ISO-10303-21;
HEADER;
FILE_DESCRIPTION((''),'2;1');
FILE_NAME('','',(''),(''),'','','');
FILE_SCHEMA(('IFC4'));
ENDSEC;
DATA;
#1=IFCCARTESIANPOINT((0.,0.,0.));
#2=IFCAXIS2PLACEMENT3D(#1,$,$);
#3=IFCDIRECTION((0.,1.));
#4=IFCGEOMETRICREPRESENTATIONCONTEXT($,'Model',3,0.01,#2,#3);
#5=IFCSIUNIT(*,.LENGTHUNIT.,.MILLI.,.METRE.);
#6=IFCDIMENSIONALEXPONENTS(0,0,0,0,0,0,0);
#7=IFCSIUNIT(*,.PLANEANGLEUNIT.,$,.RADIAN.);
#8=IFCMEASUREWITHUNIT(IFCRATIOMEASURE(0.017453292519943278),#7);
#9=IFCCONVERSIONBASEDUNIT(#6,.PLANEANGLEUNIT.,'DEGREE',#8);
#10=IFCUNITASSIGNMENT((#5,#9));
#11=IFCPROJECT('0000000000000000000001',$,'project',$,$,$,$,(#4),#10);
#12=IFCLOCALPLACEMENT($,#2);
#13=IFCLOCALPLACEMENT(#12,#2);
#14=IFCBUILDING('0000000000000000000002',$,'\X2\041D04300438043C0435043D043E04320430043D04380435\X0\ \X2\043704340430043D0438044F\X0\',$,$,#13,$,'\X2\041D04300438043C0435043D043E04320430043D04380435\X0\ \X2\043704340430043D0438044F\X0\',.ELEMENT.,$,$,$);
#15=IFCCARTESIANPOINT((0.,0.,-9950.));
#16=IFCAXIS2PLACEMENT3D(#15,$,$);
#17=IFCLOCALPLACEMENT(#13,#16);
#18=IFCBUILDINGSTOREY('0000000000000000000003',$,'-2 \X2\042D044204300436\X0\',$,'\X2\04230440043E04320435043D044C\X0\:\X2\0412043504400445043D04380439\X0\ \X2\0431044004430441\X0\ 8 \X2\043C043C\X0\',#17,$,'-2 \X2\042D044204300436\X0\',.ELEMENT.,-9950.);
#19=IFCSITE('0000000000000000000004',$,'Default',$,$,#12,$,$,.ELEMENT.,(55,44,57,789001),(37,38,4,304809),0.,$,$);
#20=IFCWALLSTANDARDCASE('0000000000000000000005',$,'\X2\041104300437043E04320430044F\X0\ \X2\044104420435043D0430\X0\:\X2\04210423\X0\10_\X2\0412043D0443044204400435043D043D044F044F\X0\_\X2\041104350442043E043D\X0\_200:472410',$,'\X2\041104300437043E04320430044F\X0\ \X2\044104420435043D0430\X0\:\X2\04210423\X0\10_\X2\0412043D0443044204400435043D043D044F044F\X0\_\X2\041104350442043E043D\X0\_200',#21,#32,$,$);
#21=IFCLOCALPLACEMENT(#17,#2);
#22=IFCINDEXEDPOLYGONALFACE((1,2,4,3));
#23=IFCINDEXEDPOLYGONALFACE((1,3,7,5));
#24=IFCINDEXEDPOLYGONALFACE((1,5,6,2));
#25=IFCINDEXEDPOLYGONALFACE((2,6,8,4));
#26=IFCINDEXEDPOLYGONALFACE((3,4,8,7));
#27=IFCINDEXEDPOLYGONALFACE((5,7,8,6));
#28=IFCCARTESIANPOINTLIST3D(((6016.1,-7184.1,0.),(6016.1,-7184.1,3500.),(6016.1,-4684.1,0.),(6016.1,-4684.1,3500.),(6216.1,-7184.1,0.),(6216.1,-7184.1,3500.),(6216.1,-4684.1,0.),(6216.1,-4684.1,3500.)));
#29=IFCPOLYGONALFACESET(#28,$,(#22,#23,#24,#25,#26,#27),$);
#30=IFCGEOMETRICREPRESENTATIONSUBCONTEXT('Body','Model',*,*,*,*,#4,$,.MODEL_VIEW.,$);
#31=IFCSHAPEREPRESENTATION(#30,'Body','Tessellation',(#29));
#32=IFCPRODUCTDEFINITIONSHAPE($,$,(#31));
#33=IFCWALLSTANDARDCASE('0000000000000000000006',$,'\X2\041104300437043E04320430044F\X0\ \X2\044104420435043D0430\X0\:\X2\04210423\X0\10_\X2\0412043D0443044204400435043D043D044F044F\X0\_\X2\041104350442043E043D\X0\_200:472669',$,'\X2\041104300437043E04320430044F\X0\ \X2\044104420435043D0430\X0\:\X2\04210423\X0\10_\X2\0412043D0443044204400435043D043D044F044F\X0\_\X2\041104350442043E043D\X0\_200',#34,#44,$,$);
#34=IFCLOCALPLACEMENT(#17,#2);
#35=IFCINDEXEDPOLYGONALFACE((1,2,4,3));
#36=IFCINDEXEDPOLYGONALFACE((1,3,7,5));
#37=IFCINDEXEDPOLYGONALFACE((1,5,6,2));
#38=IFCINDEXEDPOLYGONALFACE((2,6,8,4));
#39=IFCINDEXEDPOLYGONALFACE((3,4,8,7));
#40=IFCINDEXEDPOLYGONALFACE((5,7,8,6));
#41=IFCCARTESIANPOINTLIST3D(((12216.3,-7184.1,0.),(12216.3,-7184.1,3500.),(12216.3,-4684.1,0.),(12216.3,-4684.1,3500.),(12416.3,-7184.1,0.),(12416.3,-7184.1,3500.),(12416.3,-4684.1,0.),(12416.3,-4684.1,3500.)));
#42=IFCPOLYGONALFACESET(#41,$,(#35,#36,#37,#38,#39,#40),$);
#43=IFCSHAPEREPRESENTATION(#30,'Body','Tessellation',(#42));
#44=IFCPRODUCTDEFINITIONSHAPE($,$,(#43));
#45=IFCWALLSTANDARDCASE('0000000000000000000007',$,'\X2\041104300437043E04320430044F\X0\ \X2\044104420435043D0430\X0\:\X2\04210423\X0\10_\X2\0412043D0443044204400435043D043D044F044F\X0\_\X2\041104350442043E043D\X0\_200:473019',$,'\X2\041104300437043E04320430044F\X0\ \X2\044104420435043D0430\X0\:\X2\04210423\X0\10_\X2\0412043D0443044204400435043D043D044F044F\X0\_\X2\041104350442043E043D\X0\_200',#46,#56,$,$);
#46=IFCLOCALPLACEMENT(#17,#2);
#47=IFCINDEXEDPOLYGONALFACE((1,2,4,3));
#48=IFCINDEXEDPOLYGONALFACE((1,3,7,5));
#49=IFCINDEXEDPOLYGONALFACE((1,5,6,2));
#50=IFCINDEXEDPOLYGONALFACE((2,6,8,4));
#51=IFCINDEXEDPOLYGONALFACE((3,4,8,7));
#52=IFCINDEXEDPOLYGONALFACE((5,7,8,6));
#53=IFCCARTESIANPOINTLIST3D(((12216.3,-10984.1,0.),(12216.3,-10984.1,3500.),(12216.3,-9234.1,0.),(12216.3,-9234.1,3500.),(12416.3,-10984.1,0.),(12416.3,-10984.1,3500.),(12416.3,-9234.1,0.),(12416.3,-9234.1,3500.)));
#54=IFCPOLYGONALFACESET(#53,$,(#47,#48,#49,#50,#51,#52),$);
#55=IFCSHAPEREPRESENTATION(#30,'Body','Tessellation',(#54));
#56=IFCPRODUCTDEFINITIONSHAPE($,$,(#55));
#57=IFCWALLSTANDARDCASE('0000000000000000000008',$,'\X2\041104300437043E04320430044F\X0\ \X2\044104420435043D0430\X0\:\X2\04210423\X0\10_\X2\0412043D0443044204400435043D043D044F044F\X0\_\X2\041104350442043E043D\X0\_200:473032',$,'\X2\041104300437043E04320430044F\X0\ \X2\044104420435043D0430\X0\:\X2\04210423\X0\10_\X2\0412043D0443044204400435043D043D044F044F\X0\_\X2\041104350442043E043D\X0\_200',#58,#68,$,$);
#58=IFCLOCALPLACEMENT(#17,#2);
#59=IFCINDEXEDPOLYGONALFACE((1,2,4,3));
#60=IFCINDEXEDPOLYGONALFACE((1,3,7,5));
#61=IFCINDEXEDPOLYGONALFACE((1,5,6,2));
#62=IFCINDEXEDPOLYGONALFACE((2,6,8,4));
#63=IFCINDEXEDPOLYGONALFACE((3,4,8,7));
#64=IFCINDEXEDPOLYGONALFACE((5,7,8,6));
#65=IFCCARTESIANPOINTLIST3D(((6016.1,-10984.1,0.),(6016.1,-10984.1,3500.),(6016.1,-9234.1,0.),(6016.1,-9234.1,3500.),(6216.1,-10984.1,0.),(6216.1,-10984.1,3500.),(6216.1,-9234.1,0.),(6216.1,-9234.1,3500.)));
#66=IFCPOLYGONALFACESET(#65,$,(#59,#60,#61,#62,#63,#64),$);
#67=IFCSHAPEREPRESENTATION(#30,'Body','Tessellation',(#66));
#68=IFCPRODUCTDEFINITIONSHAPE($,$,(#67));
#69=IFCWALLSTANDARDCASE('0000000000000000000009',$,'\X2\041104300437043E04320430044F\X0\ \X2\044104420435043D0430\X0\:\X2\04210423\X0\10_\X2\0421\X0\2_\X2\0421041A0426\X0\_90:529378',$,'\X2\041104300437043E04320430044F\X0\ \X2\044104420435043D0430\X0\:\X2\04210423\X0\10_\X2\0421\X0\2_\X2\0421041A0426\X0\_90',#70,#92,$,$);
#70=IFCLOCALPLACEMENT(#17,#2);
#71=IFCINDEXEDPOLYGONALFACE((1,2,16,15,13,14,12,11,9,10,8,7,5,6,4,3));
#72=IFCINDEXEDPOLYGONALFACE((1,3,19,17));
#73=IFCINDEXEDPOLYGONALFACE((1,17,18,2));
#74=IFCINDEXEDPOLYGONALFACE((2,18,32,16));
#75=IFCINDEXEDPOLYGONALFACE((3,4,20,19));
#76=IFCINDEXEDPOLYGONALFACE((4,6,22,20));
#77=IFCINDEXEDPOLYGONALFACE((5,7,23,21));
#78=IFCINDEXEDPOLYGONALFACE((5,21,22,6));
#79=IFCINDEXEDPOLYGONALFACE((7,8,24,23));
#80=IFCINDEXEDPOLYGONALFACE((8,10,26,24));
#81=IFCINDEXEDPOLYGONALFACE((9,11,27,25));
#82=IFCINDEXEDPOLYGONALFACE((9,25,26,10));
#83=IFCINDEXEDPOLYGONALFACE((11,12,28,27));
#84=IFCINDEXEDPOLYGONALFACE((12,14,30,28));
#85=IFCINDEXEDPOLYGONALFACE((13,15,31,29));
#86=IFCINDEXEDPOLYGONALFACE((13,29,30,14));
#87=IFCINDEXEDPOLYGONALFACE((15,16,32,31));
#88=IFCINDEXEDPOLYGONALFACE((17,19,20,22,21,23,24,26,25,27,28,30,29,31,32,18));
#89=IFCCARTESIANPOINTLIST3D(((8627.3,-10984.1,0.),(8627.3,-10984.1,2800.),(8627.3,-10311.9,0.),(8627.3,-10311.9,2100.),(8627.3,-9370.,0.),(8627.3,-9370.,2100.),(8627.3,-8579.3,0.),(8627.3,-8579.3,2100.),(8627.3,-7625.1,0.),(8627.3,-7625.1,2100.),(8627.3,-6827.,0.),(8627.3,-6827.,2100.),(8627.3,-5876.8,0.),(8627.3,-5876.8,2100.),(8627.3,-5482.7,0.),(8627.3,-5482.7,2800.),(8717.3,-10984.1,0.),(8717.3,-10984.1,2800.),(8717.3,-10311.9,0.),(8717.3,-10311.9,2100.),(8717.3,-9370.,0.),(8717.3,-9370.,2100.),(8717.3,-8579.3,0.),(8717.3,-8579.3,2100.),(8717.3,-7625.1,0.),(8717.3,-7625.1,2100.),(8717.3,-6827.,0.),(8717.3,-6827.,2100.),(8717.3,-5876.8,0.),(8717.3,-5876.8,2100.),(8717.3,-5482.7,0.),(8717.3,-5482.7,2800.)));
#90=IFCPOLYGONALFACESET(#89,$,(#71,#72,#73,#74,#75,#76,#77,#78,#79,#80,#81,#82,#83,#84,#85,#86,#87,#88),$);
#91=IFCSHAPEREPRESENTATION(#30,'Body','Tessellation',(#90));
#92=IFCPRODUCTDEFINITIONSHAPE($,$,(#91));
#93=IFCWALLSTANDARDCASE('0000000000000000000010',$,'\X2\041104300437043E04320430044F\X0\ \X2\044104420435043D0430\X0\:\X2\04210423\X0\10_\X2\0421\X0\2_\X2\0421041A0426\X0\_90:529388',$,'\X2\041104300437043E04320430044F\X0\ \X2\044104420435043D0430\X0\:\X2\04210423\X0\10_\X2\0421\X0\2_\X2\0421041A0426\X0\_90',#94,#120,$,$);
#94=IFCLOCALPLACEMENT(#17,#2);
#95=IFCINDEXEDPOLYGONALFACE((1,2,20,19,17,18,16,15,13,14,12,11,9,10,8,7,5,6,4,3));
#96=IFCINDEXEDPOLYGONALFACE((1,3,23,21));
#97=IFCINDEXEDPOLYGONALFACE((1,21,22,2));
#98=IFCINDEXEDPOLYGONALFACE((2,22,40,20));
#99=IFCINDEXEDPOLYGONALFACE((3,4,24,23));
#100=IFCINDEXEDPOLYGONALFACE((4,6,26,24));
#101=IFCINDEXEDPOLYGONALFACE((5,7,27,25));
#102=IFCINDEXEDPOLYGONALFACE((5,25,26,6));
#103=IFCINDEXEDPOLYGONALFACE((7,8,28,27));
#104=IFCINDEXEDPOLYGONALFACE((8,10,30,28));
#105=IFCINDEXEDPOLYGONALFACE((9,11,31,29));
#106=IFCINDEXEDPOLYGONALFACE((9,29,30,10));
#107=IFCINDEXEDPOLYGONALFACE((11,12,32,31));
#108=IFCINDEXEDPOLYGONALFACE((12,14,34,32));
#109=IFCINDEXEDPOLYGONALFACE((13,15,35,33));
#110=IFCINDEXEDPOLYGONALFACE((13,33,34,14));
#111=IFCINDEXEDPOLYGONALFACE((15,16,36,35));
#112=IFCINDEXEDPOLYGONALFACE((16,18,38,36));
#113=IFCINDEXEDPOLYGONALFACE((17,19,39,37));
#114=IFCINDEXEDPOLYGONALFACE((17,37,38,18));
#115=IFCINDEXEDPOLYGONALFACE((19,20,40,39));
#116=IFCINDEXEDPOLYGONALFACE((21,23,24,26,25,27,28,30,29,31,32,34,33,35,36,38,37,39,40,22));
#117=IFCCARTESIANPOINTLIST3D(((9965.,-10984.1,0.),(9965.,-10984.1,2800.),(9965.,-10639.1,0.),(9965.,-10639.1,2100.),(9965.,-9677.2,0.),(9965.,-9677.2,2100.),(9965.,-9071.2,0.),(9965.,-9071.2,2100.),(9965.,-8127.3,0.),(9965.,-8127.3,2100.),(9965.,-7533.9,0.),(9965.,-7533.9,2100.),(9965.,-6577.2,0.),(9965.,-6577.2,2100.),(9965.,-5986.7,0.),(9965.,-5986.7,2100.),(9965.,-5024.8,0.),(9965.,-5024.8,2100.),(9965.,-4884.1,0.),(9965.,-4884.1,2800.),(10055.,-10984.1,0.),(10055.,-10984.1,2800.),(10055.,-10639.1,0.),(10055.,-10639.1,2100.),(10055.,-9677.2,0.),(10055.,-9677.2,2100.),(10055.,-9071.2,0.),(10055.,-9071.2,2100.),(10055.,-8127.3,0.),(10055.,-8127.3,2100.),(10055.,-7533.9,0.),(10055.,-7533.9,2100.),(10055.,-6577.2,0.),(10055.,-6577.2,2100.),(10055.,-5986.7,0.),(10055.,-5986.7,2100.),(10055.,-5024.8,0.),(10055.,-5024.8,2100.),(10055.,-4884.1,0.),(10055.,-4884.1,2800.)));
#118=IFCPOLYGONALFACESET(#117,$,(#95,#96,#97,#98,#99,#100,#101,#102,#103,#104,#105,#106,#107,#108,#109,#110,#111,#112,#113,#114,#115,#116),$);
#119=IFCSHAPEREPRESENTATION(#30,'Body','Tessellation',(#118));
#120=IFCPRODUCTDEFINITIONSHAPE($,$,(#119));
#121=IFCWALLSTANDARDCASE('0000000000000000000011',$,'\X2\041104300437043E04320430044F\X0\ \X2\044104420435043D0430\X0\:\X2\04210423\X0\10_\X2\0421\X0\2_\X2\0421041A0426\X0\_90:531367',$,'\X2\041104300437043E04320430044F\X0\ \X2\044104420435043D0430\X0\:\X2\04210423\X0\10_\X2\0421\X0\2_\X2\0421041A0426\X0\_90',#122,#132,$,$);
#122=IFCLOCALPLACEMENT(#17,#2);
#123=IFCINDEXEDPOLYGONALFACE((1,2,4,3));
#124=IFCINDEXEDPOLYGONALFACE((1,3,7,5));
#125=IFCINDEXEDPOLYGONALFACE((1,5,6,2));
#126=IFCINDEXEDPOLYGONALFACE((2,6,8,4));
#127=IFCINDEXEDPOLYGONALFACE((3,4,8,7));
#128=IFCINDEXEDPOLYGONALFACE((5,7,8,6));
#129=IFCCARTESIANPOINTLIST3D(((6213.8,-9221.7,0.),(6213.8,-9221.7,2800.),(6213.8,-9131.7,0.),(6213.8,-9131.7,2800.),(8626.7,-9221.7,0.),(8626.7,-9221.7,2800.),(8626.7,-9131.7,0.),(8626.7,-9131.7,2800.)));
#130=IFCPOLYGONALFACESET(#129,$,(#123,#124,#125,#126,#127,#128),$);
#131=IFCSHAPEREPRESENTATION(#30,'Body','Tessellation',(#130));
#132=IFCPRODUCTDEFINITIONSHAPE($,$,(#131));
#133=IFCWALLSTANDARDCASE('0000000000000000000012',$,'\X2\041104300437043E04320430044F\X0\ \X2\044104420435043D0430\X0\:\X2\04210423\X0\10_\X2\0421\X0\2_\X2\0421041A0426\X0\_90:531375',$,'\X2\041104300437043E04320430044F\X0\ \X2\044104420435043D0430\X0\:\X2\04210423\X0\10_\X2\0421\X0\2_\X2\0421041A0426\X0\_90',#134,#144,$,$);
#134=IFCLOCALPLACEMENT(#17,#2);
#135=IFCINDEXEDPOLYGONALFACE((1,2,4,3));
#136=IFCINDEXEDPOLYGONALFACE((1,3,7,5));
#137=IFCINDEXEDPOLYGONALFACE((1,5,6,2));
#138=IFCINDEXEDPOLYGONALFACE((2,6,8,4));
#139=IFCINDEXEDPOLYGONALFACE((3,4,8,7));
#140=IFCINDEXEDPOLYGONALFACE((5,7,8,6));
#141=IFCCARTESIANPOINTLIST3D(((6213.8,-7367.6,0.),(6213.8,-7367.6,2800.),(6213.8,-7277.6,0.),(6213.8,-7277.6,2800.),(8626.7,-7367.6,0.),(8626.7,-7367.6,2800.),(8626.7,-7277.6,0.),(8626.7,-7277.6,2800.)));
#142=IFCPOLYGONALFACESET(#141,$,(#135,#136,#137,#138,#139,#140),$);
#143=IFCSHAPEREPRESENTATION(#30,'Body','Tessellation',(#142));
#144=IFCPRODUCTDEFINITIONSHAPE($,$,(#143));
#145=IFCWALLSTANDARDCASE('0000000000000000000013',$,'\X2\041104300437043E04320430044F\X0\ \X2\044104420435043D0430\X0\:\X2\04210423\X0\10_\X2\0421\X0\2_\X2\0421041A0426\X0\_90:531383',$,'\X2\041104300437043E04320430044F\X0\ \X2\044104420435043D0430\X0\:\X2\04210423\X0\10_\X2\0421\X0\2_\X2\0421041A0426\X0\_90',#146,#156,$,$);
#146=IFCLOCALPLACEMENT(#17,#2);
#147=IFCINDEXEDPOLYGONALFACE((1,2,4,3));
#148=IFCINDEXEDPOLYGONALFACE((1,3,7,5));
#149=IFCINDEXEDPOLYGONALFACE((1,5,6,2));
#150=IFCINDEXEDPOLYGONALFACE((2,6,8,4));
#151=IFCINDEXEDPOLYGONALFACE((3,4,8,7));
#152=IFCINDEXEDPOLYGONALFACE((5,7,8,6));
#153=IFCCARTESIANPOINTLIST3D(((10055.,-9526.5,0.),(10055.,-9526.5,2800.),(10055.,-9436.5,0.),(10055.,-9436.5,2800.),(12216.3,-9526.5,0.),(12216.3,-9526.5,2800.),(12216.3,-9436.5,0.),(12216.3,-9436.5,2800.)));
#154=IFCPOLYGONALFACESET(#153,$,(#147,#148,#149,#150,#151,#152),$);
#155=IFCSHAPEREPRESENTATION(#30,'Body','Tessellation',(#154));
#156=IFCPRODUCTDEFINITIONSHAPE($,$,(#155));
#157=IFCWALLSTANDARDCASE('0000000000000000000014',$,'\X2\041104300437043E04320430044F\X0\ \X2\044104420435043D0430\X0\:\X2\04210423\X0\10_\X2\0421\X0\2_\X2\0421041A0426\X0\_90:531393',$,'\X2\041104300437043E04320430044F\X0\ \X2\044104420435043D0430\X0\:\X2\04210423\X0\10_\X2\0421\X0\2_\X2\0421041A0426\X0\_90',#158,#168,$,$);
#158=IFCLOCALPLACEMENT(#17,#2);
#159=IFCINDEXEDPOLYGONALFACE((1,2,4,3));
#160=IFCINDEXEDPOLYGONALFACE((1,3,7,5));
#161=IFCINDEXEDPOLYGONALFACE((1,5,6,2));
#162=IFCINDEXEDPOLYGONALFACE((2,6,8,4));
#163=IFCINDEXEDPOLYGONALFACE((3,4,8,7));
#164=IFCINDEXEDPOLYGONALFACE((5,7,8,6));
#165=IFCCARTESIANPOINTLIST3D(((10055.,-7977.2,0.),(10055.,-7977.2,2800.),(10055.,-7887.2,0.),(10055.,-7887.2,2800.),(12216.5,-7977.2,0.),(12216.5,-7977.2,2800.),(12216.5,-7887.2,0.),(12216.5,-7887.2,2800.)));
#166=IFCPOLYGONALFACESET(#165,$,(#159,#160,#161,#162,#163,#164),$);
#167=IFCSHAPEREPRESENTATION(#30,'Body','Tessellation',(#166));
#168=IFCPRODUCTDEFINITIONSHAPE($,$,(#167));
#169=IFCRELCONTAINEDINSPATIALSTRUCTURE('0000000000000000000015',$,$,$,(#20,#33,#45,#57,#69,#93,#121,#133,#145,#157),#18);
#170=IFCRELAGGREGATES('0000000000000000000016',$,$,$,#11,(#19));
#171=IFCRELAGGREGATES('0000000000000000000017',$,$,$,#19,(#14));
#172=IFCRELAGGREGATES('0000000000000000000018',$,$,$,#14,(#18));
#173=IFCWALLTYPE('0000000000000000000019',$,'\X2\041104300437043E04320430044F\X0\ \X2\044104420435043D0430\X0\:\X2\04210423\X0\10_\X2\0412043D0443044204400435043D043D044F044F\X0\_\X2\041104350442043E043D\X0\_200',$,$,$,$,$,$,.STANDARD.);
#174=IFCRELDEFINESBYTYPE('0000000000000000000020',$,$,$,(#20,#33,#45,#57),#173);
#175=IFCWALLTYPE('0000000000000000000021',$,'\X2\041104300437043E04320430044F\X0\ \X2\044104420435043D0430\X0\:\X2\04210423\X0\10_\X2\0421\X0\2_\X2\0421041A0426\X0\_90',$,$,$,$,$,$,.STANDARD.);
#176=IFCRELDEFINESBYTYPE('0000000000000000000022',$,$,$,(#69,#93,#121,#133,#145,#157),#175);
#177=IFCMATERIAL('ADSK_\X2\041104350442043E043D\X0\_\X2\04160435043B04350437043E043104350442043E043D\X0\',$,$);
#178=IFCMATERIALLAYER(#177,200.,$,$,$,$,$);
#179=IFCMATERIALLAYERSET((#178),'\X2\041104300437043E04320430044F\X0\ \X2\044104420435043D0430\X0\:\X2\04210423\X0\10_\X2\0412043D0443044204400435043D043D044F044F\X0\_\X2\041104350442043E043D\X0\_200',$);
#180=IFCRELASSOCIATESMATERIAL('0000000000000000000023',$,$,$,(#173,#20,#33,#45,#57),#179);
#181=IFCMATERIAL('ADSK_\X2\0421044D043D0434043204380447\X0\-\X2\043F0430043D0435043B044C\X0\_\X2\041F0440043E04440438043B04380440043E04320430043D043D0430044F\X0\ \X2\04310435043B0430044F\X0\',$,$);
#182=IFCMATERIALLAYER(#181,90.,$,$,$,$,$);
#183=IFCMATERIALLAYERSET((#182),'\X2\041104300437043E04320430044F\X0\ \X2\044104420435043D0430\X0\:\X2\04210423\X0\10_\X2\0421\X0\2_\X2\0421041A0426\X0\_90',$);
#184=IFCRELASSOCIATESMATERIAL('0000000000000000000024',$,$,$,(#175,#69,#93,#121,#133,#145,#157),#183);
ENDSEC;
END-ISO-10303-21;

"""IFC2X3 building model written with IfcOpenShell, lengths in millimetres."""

from ifc_helpers import new_model, entity, si_unit, converted_unit, direction, frame, frame_2d, origin, place, context, subcontext, project, spatial, rectangle, extrude, material, layer, layer_set, layer_usage, type_object, element, save


model = new_model("IFC2X3")

# Units and contexts
model_context = context("Model", 3, precision=0.01, world=origin(), true_north=direction((0.0, 1.0)))
body_context = subcontext(model_context, "Body", "Model", "MODEL_VIEW")
ifc_project = project(units=[si_unit("LENGTHUNIT", "METRE", prefix="MILLI"), converted_unit("PLANEANGLEUNIT", "DEGREE", entity("IfcRatioMeasure", 0.017453292519943278), si_unit("PLANEANGLEUNIT", "RADIAN"), dimensions=[0, 0, 0, 0, 0, 0, 0])], contexts=[model_context])

# Site, building, storey
site_placement = place(None, origin())
site = spatial("IfcSite", under=ifc_project, at=site_placement, Name="Default", CompositionType="ELEMENT", RefLatitude=(55, 44, 57, 789001), RefLongitude=(37, 38, 4, 304809), RefElevation=0.0)
building_placement = place(site_placement, origin())
building = spatial("IfcBuilding", under=site, at=building_placement, Name="Наименование здания", LongName="Наименование здания", CompositionType="ELEMENT")
storey_placement = place(building_placement, frame((0.0, 0.0, -9950.0)))
storey = spatial("IfcBuildingStorey", under=building, at=storey_placement, Name="-2 Этаж", ObjectType="Уровень:Верхний брус 8 мм", LongName="-2 Этаж", CompositionType="ELEMENT", Elevation=-9950.0)

# Walls
ifc_material_1 = material(Name="ADSK_Бетон_Железобетон")
ifc_layer_1 = layer(ifc_material_1, 200.0)
ifc_layer_set_1 = layer_set([ifc_layer_1], Name="Базовая стена:СУ10_Внутренняя_Бетон_200")
ifc_layer_usage_1 = layer_usage(ifc_layer_set_1, "AXIS2", "NEGATIVE", 100.0)
wall_type_1 = type_object("IfcWallType", Name="Базовая стена:СУ10_Внутренняя_Бетон_200", PredefinedType="STANDARD", material=ifc_layer_set_1)
wall_1_placement = place(storey_placement, frame((6116.1, -4684.1, 0.0), z_axis=(0.0, 0.0, 1.0), x_axis=(0.0, -1.0, 0.0)))
element("IfcWallStandardCase", 1, at=wall_1_placement, inside=storey, type_object=wall_type_1, material=ifc_layer_usage_1, Name="Базовая стена:СУ10_Внутренняя_Бетон_200:472410", ObjectType="Базовая стена:СУ10_Внутренняя_Бетон_200", context=body_context, shape_type="SweptSolid", body=[
    extrude(rectangle(XDim=2500.0, YDim=200.0, at=frame_2d((1250.0, 0.0), x_axis=(-1.0, 0.0))), origin(), (0.0, 0.0, 1.0), 3500.0),
])
wall_2_placement = place(storey_placement, frame((12316.3, -4684.1, 0.0), z_axis=(0.0, 0.0, 1.0), x_axis=(0.0, -1.0, 0.0)))
element("IfcWallStandardCase", 2, at=wall_2_placement, inside=storey, type_object=wall_type_1, material=ifc_layer_usage_1, Name="Базовая стена:СУ10_Внутренняя_Бетон_200:472669", ObjectType="Базовая стена:СУ10_Внутренняя_Бетон_200", context=body_context, shape_type="SweptSolid", body=[
    extrude(rectangle(XDim=2500.0, YDim=200.0, at=frame_2d((1250.0, 0.0), x_axis=(-1.0, 0.0))), origin(), (0.0, 0.0, 1.0), 3500.0),
])
wall_3_placement = place(storey_placement, frame((12316.3, -9234.1, 0.0), z_axis=(0.0, 0.0, 1.0), x_axis=(0.0, -1.0, 0.0)))
element("IfcWallStandardCase", 3, at=wall_3_placement, inside=storey, type_object=wall_type_1, material=ifc_layer_usage_1, Name="Базовая стена:СУ10_Внутренняя_Бетон_200:473019", ObjectType="Базовая стена:СУ10_Внутренняя_Бетон_200", context=body_context, shape_type="SweptSolid", body=[
    extrude(rectangle(XDim=1750.0, YDim=200.0, at=frame_2d((875.0, 0.0), x_axis=(-1.0, 0.0))), origin(), (0.0, 0.0, 1.0), 3500.0),
])
wall_4_placement = place(storey_placement, frame((6116.1, -9234.1, 0.0), z_axis=(0.0, 0.0, 1.0), x_axis=(0.0, -1.0, 0.0)))
element("IfcWallStandardCase", 4, at=wall_4_placement, inside=storey, type_object=wall_type_1, material=ifc_layer_usage_1, Name="Базовая стена:СУ10_Внутренняя_Бетон_200:473032", ObjectType="Базовая стена:СУ10_Внутренняя_Бетон_200", context=body_context, shape_type="SweptSolid", body=[
    extrude(rectangle(XDim=1750.0, YDim=200.0, at=frame_2d((875.0, 0.0), x_axis=(-1.0, 0.0))), origin(), (0.0, 0.0, 1.0), 3500.0),
])

# Walls, openings
ifc_material_2 = material(Name="ADSK_Сэндвич-панель_Профилированная белая")
ifc_layer_2 = layer(ifc_material_2, 90.0)
ifc_layer_set_2 = layer_set([ifc_layer_2], Name="Базовая стена:СУ10_С2_СКЦ_90")
ifc_layer_usage_2 = layer_usage(ifc_layer_set_2, "AXIS2", "NEGATIVE", 45.0)
wall_type_2 = type_object("IfcWallType", Name="Базовая стена:СУ10_С2_СКЦ_90", PredefinedType="STANDARD", material=ifc_layer_set_2)
wall_5_placement = place(storey_placement, frame((8672.3, -5482.7, 0.0), z_axis=(0.0, 0.0, 1.0), x_axis=(0.0, -1.0, 0.0)))
wall_5 = element("IfcWallStandardCase", 5, at=wall_5_placement, inside=storey, type_object=wall_type_2, material=ifc_layer_usage_2, Name="Базовая стена:СУ10_С2_СКЦ_90:529378", ObjectType="Базовая стена:СУ10_С2_СКЦ_90", context=body_context, shape_type="SweptSolid", body=[
    extrude(rectangle(XDim=5501.4, YDim=90.0, at=frame_2d((2750.7, 0.0), x_axis=(1.0, 0.0))), origin(), (0.0, 0.0, 1.0), 2800.0),
])
opening_1_placement = place(wall_5_placement, origin())
element("IfcOpeningElement", 6, at=opening_1_placement, cuts=wall_5, ObjectType="Opening", context=body_context, shape_type="SweptSolid", body=[
    extrude(rectangle(XDim=2100.0, YDim=941.9, at=frame_2d((0.0, 0.0), x_axis=(1.0, 0.0))), frame((4358.3, -45.0, 1050.0), z_axis=(0.0, 1.0, 0.0), x_axis=(0.0, 0.0, -1.0)), (0.0, 0.0, 1.0), 90.0),
])
opening_2_placement = place(wall_5_placement, origin())
element("IfcOpeningElement", 7, at=opening_2_placement, cuts=wall_5, ObjectType="Opening", context=body_context, shape_type="SweptSolid", body=[
    extrude(rectangle(XDim=2100.0, YDim=954.2, at=frame_2d((0.0, 0.0), x_axis=(1.0, 0.0))), frame((2619.5, -45.0, 1050.0), z_axis=(0.0, 1.0, 0.0), x_axis=(0.0, 0.0, -1.0)), (0.0, 0.0, 1.0), 90.0),
])
opening_3_placement = place(wall_5_placement, origin())
element("IfcOpeningElement", 8, at=opening_3_placement, cuts=wall_5, ObjectType="Opening", context=body_context, shape_type="SweptSolid", body=[
    extrude(rectangle(XDim=2100.0, YDim=950.2, at=frame_2d((0.0, 0.0), x_axis=(1.0, 0.0))), frame((869.2, -45.0, 1050.0), z_axis=(0.0, 1.0, 0.0), x_axis=(0.0, 0.0, -1.0)), (0.0, 0.0, 1.0), 90.0),
])
wall_6_placement = place(storey_placement, frame((10010.0, -4884.1, 0.0), z_axis=(0.0, 0.0, 1.0), x_axis=(0.0, -1.0, 0.0)))
wall_6 = element("IfcWallStandardCase", 9, at=wall_6_placement, inside=storey, type_object=wall_type_2, material=ifc_layer_usage_2, Name="Базовая стена:СУ10_С2_СКЦ_90:529388", ObjectType="Базовая стена:СУ10_С2_СКЦ_90", context=body_context, shape_type="SweptSolid", body=[
    extrude(rectangle(XDim=6100.0, YDim=90.0, at=frame_2d((3050.0, 0.0), x_axis=(-1.0, 0.0))), origin(), (0.0, 0.0, 1.0), 2800.0),
])
opening_4_placement = place(wall_6_placement, origin())
element("IfcOpeningElement", 10, at=opening_4_placement, cuts=wall_6, ObjectType="Opening", context=body_context, shape_type="SweptSolid", body=[
    extrude(rectangle(XDim=2100.0, YDim=962.0, at=frame_2d((0.0, 0.0), x_axis=(1.0, 0.0))), frame((5274.0, -45.0, 1050.0), z_axis=(0.0, 1.0, 0.0), x_axis=(0.0, 0.0, -1.0)), (0.0, 0.0, 1.0), 90.0),
])
opening_5_placement = place(wall_6_placement, origin())
element("IfcOpeningElement", 11, at=opening_5_placement, cuts=wall_6, ObjectType="Opening", context=body_context, shape_type="SweptSolid", body=[
    extrude(rectangle(XDim=2100.0, YDim=944.0, at=frame_2d((0.0, 0.0), x_axis=(1.0, 0.0))), frame((3715.2, -45.0, 1050.0), z_axis=(0.0, 1.0, 0.0), x_axis=(0.0, 0.0, -1.0)), (0.0, 0.0, 1.0), 90.0),
])
opening_6_placement = place(wall_6_placement, origin())
element("IfcOpeningElement", 12, at=opening_6_placement, cuts=wall_6, ObjectType="Opening", context=body_context, shape_type="SweptSolid", body=[
    extrude(rectangle(XDim=2100.0, YDim=956.8, at=frame_2d((0.0, 0.0), x_axis=(1.0, 0.0))), frame((2171.4, -45.0, 1050.0), z_axis=(0.0, 1.0, 0.0), x_axis=(0.0, 0.0, -1.0)), (0.0, 0.0, 1.0), 90.0),
])
opening_7_placement = place(wall_6_placement, origin())
element("IfcOpeningElement", 13, at=opening_7_placement, cuts=wall_6, ObjectType="Opening", context=body_context, shape_type="SweptSolid", body=[
    extrude(rectangle(XDim=2100.0, YDim=962.0, at=frame_2d((0.0, 0.0), x_axis=(1.0, 0.0))), frame((621.6, -45.0, 1050.0), z_axis=(0.0, 1.0, 0.0), x_axis=(0.0, 0.0, -1.0)), (0.0, 0.0, 1.0), 90.0),
])

# Walls
for number, where, z_axis, x_axis, name in (
    (14, (8626.7, -9176.7, 0.0), (0.0, 0.0, 1.0), (-1.0, 0.0, 0.0), "Базовая стена:СУ10_С2_СКЦ_90:531367"),
    (15, (8626.7, -7322.6, 0.0), (0.0, 0.0, 1.0), (-1.0, 0.0, 0.0), "Базовая стена:СУ10_С2_СКЦ_90:531375"),
):
    element("IfcWallStandardCase", number, at=place(storey_placement, frame(where, z_axis=z_axis, x_axis=x_axis)), inside=storey, type_object=wall_type_2, material=ifc_layer_usage_2, Name=name, ObjectType="Базовая стена:СУ10_С2_СКЦ_90", context=body_context, shape_type="SweptSolid", body=[
        extrude(rectangle(XDim=2412.9, YDim=90.0, at=frame_2d((1206.5, 0.0), x_axis=(-1.0, 0.0))), origin(), (0.0, 0.0, 1.0), 2800.0),
    ])
wall_7_placement = place(storey_placement, frame((12216.3, -9481.5, 0.0), z_axis=(0.0, 0.0, 1.0), x_axis=(-1.0, 0.0, 0.0)))
element("IfcWallStandardCase", 16, at=wall_7_placement, inside=storey, type_object=wall_type_2, material=ifc_layer_usage_2, Name="Базовая стена:СУ10_С2_СКЦ_90:531383", ObjectType="Базовая стена:СУ10_С2_СКЦ_90", context=body_context, shape_type="SweptSolid", body=[
    extrude(rectangle(XDim=2161.3, YDim=90.0, at=frame_2d((1080.7, 0.0), x_axis=(-1.0, 0.0))), origin(), (0.0, 0.0, 1.0), 2800.0),
])
wall_8_placement = place(storey_placement, frame((12216.5, -7932.2, 0.0), z_axis=(0.0, 0.0, 1.0), x_axis=(-1.0, 0.0, 0.0)))
element("IfcWallStandardCase", 17, at=wall_8_placement, inside=storey, type_object=wall_type_2, material=ifc_layer_usage_2, Name="Базовая стена:СУ10_С2_СКЦ_90:531393", ObjectType="Базовая стена:СУ10_С2_СКЦ_90", context=body_context, shape_type="SweptSolid", body=[
    extrude(rectangle(XDim=2161.5, YDim=90.0, at=frame_2d((1080.7, 0.0), x_axis=(-1.0, 0.0))), origin(), (0.0, 0.0, 1.0), 2800.0),
])

save(model, "model.ifc")
